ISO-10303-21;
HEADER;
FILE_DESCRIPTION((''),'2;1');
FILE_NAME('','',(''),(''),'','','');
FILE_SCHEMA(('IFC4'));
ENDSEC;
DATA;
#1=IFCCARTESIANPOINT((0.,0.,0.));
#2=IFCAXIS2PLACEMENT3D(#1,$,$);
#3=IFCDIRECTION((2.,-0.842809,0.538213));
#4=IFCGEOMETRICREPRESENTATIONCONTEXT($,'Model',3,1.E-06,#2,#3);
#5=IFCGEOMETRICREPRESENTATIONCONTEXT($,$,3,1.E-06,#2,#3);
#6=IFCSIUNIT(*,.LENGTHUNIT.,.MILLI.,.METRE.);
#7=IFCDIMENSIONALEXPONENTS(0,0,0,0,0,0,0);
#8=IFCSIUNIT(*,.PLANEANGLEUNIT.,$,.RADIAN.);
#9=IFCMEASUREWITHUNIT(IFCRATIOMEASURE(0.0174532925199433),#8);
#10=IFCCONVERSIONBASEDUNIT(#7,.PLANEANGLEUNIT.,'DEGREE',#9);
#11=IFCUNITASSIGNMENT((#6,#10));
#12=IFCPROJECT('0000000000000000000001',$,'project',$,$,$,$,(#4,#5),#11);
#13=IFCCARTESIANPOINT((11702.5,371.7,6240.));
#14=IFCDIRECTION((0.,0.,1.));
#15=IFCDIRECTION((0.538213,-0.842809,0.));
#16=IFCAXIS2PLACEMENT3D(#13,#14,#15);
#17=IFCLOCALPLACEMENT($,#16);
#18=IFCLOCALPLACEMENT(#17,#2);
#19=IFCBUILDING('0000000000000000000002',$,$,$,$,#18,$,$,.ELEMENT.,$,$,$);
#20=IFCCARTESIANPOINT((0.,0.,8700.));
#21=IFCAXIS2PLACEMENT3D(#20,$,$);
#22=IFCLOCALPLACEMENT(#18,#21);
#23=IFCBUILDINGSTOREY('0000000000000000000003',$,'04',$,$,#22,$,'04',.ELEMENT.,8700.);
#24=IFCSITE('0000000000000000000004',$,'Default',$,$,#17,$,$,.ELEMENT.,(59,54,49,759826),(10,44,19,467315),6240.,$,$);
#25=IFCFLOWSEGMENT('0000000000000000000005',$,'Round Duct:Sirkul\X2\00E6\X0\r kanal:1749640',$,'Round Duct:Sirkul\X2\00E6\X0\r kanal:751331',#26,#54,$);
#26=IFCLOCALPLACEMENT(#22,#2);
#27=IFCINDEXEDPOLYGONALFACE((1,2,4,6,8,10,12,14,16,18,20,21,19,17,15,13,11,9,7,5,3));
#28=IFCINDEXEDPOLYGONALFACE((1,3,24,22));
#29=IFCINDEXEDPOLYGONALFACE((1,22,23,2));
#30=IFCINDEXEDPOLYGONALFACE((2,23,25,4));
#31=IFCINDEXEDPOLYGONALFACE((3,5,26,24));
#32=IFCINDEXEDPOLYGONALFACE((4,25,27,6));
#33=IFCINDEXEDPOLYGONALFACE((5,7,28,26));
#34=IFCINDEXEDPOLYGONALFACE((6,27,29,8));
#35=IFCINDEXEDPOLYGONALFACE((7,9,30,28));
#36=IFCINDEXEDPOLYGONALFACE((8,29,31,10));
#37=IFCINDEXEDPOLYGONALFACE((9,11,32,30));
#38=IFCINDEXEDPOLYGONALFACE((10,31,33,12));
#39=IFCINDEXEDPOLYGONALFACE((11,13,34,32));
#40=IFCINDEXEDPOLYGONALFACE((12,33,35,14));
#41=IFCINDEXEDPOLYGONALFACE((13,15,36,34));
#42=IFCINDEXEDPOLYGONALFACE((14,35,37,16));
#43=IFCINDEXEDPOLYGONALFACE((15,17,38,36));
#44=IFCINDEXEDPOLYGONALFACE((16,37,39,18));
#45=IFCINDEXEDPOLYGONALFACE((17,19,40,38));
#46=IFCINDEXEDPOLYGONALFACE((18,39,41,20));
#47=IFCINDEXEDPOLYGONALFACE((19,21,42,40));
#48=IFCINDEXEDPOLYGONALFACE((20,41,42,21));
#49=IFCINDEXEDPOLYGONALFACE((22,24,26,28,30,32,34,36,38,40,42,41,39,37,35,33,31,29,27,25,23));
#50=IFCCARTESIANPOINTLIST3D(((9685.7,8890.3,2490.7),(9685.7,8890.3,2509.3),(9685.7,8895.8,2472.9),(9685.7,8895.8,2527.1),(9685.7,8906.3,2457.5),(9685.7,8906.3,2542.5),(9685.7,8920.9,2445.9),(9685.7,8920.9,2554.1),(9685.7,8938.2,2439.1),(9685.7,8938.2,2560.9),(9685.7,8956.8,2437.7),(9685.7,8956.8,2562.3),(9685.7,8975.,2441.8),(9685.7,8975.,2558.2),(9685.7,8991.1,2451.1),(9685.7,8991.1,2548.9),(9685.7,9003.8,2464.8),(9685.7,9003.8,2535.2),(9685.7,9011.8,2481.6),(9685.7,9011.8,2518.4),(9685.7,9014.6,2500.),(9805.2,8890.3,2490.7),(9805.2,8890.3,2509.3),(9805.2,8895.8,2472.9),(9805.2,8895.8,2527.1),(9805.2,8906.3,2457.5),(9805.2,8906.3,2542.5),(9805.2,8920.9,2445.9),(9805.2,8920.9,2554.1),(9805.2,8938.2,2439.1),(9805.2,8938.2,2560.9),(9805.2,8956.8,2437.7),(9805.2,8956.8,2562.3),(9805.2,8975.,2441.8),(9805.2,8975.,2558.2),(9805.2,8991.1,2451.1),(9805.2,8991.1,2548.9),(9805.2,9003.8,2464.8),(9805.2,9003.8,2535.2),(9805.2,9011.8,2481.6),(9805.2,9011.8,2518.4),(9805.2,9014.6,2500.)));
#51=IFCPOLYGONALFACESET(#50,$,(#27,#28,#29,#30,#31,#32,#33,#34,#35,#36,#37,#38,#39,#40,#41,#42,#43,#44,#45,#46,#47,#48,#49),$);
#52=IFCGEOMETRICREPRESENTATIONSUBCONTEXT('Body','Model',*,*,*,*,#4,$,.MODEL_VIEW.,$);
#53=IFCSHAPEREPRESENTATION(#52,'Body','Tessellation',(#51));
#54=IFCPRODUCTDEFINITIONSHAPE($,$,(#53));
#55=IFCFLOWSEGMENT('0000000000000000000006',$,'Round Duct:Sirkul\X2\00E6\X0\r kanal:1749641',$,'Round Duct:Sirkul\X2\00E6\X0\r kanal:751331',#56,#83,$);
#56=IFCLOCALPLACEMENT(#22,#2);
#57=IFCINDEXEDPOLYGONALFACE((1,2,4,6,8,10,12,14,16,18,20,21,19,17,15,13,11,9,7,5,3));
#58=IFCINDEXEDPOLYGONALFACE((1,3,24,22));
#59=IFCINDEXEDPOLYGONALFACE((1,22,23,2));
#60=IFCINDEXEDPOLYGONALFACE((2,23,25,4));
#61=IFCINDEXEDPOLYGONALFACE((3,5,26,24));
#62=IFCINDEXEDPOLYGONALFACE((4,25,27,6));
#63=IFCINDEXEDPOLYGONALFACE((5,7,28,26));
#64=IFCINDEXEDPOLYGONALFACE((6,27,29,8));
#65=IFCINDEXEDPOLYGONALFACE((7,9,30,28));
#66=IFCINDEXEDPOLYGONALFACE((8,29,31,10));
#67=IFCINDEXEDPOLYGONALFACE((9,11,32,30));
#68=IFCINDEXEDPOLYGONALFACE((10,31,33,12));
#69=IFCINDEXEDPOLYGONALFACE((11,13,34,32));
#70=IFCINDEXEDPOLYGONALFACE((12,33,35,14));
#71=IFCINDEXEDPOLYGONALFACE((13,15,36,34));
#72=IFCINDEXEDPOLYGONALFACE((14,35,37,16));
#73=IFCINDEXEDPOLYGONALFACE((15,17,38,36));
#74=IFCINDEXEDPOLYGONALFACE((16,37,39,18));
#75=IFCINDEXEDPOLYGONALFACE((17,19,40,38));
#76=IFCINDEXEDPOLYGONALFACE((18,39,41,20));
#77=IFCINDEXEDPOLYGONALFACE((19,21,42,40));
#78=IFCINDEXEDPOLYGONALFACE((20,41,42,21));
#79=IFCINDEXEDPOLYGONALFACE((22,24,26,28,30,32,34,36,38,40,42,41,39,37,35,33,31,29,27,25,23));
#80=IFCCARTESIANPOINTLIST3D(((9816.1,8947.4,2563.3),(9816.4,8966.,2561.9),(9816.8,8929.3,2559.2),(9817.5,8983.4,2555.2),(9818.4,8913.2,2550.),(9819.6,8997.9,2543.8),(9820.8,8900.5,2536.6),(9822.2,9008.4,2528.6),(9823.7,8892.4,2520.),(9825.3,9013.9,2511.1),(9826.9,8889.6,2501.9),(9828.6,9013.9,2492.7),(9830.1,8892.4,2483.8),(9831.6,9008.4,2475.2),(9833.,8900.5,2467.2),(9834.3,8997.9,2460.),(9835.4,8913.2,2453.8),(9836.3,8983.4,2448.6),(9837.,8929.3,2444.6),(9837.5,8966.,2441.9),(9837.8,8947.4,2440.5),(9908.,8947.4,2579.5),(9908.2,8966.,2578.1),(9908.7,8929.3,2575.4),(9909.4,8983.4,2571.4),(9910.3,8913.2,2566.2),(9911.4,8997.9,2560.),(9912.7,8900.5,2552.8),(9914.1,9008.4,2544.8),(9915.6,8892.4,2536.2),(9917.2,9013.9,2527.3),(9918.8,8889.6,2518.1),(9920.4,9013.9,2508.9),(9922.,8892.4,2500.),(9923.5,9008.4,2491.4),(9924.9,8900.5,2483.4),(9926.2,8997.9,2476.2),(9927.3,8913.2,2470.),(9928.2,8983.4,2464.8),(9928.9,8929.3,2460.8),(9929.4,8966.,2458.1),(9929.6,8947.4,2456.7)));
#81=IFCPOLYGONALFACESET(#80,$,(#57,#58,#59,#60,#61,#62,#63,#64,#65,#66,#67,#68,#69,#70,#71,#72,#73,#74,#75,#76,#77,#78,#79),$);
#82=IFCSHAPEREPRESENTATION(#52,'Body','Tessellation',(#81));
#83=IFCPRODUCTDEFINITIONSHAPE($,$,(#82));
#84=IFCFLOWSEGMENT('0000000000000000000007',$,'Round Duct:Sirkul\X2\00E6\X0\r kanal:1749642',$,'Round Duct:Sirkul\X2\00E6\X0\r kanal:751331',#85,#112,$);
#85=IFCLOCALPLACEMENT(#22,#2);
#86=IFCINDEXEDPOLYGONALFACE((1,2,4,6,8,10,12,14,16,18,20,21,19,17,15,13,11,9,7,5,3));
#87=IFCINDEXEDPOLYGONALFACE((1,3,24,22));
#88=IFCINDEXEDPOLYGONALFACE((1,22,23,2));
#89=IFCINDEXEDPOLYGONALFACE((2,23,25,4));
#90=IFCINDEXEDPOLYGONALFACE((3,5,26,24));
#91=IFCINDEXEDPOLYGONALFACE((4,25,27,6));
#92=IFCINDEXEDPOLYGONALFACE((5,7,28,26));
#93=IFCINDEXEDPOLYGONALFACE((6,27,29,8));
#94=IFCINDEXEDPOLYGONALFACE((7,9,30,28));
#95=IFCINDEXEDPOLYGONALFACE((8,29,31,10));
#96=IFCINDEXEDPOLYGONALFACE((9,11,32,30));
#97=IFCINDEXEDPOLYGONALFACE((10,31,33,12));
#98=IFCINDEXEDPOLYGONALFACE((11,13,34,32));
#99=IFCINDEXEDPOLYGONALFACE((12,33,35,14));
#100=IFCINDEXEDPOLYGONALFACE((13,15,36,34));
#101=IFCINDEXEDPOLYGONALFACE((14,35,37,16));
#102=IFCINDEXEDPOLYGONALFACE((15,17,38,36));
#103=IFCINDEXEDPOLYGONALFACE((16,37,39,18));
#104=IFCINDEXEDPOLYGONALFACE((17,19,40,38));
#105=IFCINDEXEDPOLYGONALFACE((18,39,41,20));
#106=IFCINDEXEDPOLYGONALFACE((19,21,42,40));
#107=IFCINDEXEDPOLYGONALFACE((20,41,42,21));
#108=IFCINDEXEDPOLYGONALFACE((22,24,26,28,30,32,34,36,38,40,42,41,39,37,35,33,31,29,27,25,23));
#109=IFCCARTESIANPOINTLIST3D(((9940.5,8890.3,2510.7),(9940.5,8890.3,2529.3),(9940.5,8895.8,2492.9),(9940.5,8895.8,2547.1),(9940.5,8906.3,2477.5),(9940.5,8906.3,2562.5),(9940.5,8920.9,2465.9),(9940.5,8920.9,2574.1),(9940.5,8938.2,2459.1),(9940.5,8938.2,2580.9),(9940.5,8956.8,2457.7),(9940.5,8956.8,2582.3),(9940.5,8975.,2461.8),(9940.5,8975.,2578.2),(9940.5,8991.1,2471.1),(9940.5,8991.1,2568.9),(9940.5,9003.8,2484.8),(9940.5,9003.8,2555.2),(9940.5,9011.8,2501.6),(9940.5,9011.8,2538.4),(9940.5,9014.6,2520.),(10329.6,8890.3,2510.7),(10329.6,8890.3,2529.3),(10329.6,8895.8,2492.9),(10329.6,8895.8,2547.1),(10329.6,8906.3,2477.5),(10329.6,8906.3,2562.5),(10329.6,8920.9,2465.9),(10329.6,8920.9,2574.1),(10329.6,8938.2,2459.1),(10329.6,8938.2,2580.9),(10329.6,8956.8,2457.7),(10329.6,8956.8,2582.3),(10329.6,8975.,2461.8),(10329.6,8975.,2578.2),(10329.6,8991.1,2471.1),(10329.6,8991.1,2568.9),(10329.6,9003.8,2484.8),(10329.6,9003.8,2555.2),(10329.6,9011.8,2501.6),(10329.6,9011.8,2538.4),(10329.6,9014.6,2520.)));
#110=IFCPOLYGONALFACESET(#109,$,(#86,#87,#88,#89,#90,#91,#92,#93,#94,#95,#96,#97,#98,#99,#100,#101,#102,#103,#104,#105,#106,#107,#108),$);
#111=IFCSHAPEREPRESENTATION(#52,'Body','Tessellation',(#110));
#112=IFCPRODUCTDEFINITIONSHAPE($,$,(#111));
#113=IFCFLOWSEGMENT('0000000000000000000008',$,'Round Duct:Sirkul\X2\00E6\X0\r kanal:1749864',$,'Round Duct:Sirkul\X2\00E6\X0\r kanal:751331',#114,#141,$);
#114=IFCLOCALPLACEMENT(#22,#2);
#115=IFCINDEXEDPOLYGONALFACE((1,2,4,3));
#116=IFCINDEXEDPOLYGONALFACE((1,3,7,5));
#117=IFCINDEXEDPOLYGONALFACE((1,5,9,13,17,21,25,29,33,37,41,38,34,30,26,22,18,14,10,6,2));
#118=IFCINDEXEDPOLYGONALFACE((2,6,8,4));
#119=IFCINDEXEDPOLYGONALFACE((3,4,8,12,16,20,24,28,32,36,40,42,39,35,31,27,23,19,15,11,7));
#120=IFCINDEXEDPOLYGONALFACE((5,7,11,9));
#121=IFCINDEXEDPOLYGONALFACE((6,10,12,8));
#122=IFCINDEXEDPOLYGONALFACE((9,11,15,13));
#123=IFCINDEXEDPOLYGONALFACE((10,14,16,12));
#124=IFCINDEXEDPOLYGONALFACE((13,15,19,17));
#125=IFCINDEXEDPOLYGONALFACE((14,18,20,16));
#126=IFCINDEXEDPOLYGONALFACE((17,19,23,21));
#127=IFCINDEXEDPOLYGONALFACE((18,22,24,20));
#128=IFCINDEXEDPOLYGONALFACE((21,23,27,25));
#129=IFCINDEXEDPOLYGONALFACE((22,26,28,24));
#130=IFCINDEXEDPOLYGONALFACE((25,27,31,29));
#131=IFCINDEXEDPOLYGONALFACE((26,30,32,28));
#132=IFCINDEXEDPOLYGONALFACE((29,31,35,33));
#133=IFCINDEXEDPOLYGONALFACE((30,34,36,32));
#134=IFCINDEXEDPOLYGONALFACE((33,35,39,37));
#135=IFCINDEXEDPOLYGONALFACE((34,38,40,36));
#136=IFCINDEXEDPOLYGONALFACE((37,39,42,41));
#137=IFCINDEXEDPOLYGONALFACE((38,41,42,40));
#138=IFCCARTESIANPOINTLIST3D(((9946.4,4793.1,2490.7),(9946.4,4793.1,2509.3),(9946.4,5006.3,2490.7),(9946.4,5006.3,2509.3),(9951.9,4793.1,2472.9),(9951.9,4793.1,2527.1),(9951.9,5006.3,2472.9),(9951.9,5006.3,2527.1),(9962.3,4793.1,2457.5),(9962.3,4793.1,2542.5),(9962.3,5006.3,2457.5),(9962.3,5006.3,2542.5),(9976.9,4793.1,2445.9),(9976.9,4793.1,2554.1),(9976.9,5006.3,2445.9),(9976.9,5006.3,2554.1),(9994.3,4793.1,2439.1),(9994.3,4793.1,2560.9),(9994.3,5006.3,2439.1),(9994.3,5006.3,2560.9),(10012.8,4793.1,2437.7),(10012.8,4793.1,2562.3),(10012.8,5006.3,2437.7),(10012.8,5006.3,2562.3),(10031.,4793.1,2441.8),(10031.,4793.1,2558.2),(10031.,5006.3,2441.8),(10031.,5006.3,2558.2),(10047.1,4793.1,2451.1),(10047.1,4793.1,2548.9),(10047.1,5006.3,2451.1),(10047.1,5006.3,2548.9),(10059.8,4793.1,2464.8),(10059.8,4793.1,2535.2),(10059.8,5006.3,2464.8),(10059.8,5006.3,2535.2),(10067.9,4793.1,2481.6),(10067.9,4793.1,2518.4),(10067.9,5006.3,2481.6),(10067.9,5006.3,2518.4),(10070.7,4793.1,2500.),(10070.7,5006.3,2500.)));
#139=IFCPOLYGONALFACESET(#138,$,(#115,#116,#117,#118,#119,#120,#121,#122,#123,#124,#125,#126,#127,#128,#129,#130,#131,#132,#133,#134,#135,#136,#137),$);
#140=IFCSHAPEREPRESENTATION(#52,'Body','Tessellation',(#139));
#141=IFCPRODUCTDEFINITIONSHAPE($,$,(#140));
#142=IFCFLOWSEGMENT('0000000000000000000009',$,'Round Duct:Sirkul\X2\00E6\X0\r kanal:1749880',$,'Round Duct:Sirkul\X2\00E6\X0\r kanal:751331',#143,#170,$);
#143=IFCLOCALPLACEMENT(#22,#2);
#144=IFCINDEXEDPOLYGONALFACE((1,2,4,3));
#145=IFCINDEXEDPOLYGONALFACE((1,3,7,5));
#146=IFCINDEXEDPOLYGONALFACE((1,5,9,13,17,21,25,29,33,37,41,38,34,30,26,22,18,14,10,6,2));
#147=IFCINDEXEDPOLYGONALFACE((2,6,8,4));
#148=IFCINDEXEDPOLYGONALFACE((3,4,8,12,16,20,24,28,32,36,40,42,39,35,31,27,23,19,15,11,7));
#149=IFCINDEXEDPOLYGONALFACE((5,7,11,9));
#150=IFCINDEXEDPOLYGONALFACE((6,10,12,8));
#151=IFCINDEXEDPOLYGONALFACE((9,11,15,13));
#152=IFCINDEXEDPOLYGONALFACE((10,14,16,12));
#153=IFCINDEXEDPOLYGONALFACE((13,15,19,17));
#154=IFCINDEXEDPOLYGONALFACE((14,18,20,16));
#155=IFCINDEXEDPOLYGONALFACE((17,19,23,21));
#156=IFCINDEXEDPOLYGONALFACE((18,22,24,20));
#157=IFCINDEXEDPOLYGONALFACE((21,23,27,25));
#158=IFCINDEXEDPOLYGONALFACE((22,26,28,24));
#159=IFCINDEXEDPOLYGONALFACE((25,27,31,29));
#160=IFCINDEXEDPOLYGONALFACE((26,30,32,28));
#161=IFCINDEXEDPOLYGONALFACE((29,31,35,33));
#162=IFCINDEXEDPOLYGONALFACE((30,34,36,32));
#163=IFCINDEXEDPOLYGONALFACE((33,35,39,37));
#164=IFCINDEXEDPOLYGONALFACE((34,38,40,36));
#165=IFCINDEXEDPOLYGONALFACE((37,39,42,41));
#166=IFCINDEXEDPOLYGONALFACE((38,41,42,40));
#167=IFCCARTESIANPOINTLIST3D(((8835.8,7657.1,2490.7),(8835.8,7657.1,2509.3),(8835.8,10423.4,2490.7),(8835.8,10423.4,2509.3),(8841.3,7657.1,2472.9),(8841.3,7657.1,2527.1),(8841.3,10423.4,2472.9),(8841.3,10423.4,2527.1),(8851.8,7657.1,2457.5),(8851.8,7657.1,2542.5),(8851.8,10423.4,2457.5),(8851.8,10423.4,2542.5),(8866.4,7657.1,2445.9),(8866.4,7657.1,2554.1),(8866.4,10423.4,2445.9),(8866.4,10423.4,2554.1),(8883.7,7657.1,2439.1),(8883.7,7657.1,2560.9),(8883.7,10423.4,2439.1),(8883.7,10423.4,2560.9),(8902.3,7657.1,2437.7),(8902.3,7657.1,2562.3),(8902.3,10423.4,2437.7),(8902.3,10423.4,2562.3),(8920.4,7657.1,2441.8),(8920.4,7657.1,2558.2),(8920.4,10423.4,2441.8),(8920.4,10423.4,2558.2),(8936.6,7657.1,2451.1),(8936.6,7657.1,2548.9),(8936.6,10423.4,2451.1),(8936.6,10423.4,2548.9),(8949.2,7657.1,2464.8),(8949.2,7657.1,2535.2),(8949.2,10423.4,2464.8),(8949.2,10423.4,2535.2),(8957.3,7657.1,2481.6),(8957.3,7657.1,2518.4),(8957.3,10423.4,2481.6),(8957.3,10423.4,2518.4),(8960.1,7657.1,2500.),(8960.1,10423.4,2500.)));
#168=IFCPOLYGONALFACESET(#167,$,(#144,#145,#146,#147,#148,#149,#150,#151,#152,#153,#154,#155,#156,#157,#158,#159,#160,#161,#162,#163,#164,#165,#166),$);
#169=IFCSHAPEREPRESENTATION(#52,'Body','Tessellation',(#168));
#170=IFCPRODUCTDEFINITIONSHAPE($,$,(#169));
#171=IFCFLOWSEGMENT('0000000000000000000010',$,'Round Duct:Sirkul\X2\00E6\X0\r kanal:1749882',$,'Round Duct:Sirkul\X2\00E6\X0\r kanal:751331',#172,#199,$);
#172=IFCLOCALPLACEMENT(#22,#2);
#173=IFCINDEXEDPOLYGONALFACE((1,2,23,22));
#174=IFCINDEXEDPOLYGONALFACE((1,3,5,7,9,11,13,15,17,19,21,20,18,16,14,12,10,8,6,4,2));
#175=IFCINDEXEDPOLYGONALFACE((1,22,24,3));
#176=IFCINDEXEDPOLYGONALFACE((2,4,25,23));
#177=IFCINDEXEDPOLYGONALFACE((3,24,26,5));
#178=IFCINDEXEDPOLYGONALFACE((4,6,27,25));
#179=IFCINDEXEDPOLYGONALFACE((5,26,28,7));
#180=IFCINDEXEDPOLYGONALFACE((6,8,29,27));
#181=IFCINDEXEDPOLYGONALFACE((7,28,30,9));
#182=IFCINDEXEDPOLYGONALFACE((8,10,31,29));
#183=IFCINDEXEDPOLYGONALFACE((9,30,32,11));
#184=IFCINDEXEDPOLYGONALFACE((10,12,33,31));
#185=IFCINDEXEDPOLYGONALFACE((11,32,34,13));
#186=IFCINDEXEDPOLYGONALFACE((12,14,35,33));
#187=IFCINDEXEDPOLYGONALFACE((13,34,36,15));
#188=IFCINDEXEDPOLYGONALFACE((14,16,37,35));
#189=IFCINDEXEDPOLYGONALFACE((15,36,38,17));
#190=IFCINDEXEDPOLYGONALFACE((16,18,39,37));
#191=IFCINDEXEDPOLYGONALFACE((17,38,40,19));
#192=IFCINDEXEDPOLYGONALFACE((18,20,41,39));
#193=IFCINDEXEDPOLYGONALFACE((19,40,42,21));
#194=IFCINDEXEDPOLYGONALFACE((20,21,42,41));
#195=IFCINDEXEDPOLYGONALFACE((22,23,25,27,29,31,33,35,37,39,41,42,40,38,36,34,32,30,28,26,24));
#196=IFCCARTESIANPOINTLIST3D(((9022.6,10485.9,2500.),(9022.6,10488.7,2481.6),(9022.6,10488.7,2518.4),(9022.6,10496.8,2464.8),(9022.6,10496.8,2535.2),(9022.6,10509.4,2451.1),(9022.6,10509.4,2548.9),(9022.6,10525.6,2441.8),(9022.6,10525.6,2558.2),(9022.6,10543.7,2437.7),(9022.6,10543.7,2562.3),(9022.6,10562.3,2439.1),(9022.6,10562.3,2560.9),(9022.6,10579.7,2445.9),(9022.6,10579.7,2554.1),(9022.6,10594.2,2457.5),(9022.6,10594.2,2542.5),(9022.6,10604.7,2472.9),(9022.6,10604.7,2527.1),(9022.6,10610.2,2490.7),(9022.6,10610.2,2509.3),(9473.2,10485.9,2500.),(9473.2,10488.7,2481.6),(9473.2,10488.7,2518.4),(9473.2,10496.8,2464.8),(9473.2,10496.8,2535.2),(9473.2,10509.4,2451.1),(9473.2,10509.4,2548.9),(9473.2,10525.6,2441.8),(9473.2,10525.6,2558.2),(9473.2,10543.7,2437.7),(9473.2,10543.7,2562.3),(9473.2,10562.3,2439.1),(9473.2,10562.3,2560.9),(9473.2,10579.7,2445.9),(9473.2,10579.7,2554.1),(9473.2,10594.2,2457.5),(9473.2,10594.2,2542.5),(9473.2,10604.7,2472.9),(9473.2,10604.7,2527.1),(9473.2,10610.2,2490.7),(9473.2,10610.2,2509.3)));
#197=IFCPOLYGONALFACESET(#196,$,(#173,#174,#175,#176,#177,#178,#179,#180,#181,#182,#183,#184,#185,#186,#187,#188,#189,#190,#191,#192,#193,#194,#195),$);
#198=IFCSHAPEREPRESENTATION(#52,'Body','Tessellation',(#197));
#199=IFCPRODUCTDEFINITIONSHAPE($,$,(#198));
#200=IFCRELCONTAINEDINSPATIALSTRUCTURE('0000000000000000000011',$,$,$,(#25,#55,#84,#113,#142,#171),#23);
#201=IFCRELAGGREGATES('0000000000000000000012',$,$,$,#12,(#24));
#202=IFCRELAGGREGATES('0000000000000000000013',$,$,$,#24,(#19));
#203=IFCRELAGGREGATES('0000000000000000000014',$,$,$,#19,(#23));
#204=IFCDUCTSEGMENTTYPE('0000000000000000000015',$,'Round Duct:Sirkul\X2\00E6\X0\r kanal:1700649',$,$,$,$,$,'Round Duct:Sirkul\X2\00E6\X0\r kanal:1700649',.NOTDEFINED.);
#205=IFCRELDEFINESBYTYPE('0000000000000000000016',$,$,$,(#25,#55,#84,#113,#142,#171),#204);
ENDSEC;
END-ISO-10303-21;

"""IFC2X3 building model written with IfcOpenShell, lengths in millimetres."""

from ifc_helpers import new_model, entity, si_unit, converted_unit, direction, frame, frame_2d, origin, origin_2d_with_axis, place, context, subcontext, project, spatial, circle, extrude, type_object, element, save


model = new_model("IFC2X3")

# Units and contexts
model_context = context("Model", 3, precision=1e-06, world=origin(), true_north=direction((2.0, -0.842809, 0.538213)))
context_of_model = context(None, 3, precision=1e-06, world=origin(), true_north=direction((2.0, -0.842809, 0.538213)))
body_context = subcontext(model_context, "Body", "Model", "MODEL_VIEW")
ifc_project = project(units=[si_unit("LENGTHUNIT", "METRE", prefix="MILLI"), converted_unit("PLANEANGLEUNIT", "DEGREE", entity("IfcRatioMeasure", 0.0174532925199433), si_unit("PLANEANGLEUNIT", "RADIAN"), dimensions=[0, 0, 0, 0, 0, 0, 0])], contexts=[model_context, context_of_model])

# Site, building, storey
site_placement = place(None, frame((11702.5, 371.7, 6240.0), z_axis=(0.0, 0.0, 1.0), x_axis=(0.538213, -0.842809, 0.0)))
site = spatial("IfcSite", under=ifc_project, at=site_placement, Name="Default", CompositionType="ELEMENT", RefLatitude=(59, 54, 49, 759826), RefLongitude=(10, 44, 19, 467315), RefElevation=6240.0)
building_placement = place(site_placement, origin())
building = spatial("IfcBuilding", under=site, at=building_placement, CompositionType="ELEMENT")
storey_placement = place(building_placement, frame((0.0, 0.0, 8700.0)))
storey = spatial("IfcBuildingStorey", under=building, at=storey_placement, Name="04", LongName="04", CompositionType="ELEMENT", Elevation=8700.0)

# Flow segments
duct_segment_type = type_object("IfcDuctSegmentType", Name="Round Duct:Sirkulær kanal:1700649", ElementType="Round Duct:Sirkulær kanal:1700649", PredefinedType="NOTDEFINED")
flow_segment_1_placement = place(storey_placement, origin())
element("IfcFlowSegment", 1, at=flow_segment_1_placement, inside=storey, type_object=duct_segment_type, Name="Round Duct:Sirkulær kanal:1749640", ObjectType="Round Duct:Sirkulær kanal:751331", context=body_context, shape_type="SweptSolid", body=[
    extrude(circle(Radius=62.5, at=frame_2d((0.0, 0.0), x_axis=(1.0, 0.0))), frame((9685.7, 8952.1, 2500.0), z_axis=(1.0, 0.0, 0.0), x_axis=(0.0, 1.0, 0.0)), (0.0, 0.0, 1.0), 119.6),
])
flow_segment_2_placement = place(storey_placement, origin())
element("IfcFlowSegment", 2, at=flow_segment_2_placement, inside=storey, type_object=duct_segment_type, Name="Round Duct:Sirkulær kanal:1749641", ObjectType="Round Duct:Sirkulær kanal:751331", context=body_context, shape_type="SweptSolid", body=[
    extrude(circle(Radius=62.5, at=origin_2d_with_axis()), frame((9826.9, 8952.1, 2501.9), z_axis=(0.984808, 0.0, 0.173648), x_axis=(0.0, -1.0, 0.0)), (0.0, 0.0, 1.0), 93.3),
])
flow_segment_3_placement = place(storey_placement, origin())
element("IfcFlowSegment", 3, at=flow_segment_3_placement, inside=storey, type_object=duct_segment_type, Name="Round Duct:Sirkulær kanal:1749642", ObjectType="Round Duct:Sirkulær kanal:751331", context=body_context, shape_type="SweptSolid", body=[
    extrude(circle(Radius=62.5, at=frame_2d((0.0, 0.0), x_axis=(1.0, 0.0))), frame((9940.5, 8952.1, 2520.0), z_axis=(1.0, 0.0, 0.0), x_axis=(0.0, 1.0, 0.0)), (0.0, 0.0, 1.0), 389.1),
])
flow_segment_4_placement = place(storey_placement, origin())
element("IfcFlowSegment", 4, at=flow_segment_4_placement, inside=storey, type_object=duct_segment_type, Name="Round Duct:Sirkulær kanal:1749864", ObjectType="Round Duct:Sirkulær kanal:751331", context=body_context, shape_type="SweptSolid", body=[
    extrude(circle(Radius=62.5, at=origin_2d_with_axis()), frame((10008.2, 4793.1, 2500.0), z_axis=(0.0, 1.0, 0.0), x_axis=(1.0, 0.0, 0.0)), (0.0, 0.0, 1.0), 213.2),
])
flow_segment_5_placement = place(storey_placement, origin())
element("IfcFlowSegment", 5, at=flow_segment_5_placement, inside=storey, type_object=duct_segment_type, Name="Round Duct:Sirkulær kanal:1749880", ObjectType="Round Duct:Sirkulær kanal:751331", context=body_context, shape_type="SweptSolid", body=[
    extrude(circle(Radius=62.5, at=origin_2d_with_axis()), frame((8897.6, 7657.1, 2500.0), z_axis=(0.0, 1.0, 0.0), x_axis=(1.0, 0.0, 0.0)), (0.0, 0.0, 1.0), 2766.3),
])
flow_segment_6_placement = place(storey_placement, origin())
element("IfcFlowSegment", 6, at=flow_segment_6_placement, inside=storey, type_object=duct_segment_type, Name="Round Duct:Sirkulær kanal:1749882", ObjectType="Round Duct:Sirkulær kanal:751331", context=body_context, shape_type="SweptSolid", body=[
    extrude(circle(Radius=62.5, at=origin_2d_with_axis()), frame((9022.6, 10548.4, 2500.0), z_axis=(1.0, 0.0, 0.0), x_axis=(0.0, -1.0, 0.0)), (0.0, 0.0, 1.0), 450.6),
])

save(model, "model.ifc")
